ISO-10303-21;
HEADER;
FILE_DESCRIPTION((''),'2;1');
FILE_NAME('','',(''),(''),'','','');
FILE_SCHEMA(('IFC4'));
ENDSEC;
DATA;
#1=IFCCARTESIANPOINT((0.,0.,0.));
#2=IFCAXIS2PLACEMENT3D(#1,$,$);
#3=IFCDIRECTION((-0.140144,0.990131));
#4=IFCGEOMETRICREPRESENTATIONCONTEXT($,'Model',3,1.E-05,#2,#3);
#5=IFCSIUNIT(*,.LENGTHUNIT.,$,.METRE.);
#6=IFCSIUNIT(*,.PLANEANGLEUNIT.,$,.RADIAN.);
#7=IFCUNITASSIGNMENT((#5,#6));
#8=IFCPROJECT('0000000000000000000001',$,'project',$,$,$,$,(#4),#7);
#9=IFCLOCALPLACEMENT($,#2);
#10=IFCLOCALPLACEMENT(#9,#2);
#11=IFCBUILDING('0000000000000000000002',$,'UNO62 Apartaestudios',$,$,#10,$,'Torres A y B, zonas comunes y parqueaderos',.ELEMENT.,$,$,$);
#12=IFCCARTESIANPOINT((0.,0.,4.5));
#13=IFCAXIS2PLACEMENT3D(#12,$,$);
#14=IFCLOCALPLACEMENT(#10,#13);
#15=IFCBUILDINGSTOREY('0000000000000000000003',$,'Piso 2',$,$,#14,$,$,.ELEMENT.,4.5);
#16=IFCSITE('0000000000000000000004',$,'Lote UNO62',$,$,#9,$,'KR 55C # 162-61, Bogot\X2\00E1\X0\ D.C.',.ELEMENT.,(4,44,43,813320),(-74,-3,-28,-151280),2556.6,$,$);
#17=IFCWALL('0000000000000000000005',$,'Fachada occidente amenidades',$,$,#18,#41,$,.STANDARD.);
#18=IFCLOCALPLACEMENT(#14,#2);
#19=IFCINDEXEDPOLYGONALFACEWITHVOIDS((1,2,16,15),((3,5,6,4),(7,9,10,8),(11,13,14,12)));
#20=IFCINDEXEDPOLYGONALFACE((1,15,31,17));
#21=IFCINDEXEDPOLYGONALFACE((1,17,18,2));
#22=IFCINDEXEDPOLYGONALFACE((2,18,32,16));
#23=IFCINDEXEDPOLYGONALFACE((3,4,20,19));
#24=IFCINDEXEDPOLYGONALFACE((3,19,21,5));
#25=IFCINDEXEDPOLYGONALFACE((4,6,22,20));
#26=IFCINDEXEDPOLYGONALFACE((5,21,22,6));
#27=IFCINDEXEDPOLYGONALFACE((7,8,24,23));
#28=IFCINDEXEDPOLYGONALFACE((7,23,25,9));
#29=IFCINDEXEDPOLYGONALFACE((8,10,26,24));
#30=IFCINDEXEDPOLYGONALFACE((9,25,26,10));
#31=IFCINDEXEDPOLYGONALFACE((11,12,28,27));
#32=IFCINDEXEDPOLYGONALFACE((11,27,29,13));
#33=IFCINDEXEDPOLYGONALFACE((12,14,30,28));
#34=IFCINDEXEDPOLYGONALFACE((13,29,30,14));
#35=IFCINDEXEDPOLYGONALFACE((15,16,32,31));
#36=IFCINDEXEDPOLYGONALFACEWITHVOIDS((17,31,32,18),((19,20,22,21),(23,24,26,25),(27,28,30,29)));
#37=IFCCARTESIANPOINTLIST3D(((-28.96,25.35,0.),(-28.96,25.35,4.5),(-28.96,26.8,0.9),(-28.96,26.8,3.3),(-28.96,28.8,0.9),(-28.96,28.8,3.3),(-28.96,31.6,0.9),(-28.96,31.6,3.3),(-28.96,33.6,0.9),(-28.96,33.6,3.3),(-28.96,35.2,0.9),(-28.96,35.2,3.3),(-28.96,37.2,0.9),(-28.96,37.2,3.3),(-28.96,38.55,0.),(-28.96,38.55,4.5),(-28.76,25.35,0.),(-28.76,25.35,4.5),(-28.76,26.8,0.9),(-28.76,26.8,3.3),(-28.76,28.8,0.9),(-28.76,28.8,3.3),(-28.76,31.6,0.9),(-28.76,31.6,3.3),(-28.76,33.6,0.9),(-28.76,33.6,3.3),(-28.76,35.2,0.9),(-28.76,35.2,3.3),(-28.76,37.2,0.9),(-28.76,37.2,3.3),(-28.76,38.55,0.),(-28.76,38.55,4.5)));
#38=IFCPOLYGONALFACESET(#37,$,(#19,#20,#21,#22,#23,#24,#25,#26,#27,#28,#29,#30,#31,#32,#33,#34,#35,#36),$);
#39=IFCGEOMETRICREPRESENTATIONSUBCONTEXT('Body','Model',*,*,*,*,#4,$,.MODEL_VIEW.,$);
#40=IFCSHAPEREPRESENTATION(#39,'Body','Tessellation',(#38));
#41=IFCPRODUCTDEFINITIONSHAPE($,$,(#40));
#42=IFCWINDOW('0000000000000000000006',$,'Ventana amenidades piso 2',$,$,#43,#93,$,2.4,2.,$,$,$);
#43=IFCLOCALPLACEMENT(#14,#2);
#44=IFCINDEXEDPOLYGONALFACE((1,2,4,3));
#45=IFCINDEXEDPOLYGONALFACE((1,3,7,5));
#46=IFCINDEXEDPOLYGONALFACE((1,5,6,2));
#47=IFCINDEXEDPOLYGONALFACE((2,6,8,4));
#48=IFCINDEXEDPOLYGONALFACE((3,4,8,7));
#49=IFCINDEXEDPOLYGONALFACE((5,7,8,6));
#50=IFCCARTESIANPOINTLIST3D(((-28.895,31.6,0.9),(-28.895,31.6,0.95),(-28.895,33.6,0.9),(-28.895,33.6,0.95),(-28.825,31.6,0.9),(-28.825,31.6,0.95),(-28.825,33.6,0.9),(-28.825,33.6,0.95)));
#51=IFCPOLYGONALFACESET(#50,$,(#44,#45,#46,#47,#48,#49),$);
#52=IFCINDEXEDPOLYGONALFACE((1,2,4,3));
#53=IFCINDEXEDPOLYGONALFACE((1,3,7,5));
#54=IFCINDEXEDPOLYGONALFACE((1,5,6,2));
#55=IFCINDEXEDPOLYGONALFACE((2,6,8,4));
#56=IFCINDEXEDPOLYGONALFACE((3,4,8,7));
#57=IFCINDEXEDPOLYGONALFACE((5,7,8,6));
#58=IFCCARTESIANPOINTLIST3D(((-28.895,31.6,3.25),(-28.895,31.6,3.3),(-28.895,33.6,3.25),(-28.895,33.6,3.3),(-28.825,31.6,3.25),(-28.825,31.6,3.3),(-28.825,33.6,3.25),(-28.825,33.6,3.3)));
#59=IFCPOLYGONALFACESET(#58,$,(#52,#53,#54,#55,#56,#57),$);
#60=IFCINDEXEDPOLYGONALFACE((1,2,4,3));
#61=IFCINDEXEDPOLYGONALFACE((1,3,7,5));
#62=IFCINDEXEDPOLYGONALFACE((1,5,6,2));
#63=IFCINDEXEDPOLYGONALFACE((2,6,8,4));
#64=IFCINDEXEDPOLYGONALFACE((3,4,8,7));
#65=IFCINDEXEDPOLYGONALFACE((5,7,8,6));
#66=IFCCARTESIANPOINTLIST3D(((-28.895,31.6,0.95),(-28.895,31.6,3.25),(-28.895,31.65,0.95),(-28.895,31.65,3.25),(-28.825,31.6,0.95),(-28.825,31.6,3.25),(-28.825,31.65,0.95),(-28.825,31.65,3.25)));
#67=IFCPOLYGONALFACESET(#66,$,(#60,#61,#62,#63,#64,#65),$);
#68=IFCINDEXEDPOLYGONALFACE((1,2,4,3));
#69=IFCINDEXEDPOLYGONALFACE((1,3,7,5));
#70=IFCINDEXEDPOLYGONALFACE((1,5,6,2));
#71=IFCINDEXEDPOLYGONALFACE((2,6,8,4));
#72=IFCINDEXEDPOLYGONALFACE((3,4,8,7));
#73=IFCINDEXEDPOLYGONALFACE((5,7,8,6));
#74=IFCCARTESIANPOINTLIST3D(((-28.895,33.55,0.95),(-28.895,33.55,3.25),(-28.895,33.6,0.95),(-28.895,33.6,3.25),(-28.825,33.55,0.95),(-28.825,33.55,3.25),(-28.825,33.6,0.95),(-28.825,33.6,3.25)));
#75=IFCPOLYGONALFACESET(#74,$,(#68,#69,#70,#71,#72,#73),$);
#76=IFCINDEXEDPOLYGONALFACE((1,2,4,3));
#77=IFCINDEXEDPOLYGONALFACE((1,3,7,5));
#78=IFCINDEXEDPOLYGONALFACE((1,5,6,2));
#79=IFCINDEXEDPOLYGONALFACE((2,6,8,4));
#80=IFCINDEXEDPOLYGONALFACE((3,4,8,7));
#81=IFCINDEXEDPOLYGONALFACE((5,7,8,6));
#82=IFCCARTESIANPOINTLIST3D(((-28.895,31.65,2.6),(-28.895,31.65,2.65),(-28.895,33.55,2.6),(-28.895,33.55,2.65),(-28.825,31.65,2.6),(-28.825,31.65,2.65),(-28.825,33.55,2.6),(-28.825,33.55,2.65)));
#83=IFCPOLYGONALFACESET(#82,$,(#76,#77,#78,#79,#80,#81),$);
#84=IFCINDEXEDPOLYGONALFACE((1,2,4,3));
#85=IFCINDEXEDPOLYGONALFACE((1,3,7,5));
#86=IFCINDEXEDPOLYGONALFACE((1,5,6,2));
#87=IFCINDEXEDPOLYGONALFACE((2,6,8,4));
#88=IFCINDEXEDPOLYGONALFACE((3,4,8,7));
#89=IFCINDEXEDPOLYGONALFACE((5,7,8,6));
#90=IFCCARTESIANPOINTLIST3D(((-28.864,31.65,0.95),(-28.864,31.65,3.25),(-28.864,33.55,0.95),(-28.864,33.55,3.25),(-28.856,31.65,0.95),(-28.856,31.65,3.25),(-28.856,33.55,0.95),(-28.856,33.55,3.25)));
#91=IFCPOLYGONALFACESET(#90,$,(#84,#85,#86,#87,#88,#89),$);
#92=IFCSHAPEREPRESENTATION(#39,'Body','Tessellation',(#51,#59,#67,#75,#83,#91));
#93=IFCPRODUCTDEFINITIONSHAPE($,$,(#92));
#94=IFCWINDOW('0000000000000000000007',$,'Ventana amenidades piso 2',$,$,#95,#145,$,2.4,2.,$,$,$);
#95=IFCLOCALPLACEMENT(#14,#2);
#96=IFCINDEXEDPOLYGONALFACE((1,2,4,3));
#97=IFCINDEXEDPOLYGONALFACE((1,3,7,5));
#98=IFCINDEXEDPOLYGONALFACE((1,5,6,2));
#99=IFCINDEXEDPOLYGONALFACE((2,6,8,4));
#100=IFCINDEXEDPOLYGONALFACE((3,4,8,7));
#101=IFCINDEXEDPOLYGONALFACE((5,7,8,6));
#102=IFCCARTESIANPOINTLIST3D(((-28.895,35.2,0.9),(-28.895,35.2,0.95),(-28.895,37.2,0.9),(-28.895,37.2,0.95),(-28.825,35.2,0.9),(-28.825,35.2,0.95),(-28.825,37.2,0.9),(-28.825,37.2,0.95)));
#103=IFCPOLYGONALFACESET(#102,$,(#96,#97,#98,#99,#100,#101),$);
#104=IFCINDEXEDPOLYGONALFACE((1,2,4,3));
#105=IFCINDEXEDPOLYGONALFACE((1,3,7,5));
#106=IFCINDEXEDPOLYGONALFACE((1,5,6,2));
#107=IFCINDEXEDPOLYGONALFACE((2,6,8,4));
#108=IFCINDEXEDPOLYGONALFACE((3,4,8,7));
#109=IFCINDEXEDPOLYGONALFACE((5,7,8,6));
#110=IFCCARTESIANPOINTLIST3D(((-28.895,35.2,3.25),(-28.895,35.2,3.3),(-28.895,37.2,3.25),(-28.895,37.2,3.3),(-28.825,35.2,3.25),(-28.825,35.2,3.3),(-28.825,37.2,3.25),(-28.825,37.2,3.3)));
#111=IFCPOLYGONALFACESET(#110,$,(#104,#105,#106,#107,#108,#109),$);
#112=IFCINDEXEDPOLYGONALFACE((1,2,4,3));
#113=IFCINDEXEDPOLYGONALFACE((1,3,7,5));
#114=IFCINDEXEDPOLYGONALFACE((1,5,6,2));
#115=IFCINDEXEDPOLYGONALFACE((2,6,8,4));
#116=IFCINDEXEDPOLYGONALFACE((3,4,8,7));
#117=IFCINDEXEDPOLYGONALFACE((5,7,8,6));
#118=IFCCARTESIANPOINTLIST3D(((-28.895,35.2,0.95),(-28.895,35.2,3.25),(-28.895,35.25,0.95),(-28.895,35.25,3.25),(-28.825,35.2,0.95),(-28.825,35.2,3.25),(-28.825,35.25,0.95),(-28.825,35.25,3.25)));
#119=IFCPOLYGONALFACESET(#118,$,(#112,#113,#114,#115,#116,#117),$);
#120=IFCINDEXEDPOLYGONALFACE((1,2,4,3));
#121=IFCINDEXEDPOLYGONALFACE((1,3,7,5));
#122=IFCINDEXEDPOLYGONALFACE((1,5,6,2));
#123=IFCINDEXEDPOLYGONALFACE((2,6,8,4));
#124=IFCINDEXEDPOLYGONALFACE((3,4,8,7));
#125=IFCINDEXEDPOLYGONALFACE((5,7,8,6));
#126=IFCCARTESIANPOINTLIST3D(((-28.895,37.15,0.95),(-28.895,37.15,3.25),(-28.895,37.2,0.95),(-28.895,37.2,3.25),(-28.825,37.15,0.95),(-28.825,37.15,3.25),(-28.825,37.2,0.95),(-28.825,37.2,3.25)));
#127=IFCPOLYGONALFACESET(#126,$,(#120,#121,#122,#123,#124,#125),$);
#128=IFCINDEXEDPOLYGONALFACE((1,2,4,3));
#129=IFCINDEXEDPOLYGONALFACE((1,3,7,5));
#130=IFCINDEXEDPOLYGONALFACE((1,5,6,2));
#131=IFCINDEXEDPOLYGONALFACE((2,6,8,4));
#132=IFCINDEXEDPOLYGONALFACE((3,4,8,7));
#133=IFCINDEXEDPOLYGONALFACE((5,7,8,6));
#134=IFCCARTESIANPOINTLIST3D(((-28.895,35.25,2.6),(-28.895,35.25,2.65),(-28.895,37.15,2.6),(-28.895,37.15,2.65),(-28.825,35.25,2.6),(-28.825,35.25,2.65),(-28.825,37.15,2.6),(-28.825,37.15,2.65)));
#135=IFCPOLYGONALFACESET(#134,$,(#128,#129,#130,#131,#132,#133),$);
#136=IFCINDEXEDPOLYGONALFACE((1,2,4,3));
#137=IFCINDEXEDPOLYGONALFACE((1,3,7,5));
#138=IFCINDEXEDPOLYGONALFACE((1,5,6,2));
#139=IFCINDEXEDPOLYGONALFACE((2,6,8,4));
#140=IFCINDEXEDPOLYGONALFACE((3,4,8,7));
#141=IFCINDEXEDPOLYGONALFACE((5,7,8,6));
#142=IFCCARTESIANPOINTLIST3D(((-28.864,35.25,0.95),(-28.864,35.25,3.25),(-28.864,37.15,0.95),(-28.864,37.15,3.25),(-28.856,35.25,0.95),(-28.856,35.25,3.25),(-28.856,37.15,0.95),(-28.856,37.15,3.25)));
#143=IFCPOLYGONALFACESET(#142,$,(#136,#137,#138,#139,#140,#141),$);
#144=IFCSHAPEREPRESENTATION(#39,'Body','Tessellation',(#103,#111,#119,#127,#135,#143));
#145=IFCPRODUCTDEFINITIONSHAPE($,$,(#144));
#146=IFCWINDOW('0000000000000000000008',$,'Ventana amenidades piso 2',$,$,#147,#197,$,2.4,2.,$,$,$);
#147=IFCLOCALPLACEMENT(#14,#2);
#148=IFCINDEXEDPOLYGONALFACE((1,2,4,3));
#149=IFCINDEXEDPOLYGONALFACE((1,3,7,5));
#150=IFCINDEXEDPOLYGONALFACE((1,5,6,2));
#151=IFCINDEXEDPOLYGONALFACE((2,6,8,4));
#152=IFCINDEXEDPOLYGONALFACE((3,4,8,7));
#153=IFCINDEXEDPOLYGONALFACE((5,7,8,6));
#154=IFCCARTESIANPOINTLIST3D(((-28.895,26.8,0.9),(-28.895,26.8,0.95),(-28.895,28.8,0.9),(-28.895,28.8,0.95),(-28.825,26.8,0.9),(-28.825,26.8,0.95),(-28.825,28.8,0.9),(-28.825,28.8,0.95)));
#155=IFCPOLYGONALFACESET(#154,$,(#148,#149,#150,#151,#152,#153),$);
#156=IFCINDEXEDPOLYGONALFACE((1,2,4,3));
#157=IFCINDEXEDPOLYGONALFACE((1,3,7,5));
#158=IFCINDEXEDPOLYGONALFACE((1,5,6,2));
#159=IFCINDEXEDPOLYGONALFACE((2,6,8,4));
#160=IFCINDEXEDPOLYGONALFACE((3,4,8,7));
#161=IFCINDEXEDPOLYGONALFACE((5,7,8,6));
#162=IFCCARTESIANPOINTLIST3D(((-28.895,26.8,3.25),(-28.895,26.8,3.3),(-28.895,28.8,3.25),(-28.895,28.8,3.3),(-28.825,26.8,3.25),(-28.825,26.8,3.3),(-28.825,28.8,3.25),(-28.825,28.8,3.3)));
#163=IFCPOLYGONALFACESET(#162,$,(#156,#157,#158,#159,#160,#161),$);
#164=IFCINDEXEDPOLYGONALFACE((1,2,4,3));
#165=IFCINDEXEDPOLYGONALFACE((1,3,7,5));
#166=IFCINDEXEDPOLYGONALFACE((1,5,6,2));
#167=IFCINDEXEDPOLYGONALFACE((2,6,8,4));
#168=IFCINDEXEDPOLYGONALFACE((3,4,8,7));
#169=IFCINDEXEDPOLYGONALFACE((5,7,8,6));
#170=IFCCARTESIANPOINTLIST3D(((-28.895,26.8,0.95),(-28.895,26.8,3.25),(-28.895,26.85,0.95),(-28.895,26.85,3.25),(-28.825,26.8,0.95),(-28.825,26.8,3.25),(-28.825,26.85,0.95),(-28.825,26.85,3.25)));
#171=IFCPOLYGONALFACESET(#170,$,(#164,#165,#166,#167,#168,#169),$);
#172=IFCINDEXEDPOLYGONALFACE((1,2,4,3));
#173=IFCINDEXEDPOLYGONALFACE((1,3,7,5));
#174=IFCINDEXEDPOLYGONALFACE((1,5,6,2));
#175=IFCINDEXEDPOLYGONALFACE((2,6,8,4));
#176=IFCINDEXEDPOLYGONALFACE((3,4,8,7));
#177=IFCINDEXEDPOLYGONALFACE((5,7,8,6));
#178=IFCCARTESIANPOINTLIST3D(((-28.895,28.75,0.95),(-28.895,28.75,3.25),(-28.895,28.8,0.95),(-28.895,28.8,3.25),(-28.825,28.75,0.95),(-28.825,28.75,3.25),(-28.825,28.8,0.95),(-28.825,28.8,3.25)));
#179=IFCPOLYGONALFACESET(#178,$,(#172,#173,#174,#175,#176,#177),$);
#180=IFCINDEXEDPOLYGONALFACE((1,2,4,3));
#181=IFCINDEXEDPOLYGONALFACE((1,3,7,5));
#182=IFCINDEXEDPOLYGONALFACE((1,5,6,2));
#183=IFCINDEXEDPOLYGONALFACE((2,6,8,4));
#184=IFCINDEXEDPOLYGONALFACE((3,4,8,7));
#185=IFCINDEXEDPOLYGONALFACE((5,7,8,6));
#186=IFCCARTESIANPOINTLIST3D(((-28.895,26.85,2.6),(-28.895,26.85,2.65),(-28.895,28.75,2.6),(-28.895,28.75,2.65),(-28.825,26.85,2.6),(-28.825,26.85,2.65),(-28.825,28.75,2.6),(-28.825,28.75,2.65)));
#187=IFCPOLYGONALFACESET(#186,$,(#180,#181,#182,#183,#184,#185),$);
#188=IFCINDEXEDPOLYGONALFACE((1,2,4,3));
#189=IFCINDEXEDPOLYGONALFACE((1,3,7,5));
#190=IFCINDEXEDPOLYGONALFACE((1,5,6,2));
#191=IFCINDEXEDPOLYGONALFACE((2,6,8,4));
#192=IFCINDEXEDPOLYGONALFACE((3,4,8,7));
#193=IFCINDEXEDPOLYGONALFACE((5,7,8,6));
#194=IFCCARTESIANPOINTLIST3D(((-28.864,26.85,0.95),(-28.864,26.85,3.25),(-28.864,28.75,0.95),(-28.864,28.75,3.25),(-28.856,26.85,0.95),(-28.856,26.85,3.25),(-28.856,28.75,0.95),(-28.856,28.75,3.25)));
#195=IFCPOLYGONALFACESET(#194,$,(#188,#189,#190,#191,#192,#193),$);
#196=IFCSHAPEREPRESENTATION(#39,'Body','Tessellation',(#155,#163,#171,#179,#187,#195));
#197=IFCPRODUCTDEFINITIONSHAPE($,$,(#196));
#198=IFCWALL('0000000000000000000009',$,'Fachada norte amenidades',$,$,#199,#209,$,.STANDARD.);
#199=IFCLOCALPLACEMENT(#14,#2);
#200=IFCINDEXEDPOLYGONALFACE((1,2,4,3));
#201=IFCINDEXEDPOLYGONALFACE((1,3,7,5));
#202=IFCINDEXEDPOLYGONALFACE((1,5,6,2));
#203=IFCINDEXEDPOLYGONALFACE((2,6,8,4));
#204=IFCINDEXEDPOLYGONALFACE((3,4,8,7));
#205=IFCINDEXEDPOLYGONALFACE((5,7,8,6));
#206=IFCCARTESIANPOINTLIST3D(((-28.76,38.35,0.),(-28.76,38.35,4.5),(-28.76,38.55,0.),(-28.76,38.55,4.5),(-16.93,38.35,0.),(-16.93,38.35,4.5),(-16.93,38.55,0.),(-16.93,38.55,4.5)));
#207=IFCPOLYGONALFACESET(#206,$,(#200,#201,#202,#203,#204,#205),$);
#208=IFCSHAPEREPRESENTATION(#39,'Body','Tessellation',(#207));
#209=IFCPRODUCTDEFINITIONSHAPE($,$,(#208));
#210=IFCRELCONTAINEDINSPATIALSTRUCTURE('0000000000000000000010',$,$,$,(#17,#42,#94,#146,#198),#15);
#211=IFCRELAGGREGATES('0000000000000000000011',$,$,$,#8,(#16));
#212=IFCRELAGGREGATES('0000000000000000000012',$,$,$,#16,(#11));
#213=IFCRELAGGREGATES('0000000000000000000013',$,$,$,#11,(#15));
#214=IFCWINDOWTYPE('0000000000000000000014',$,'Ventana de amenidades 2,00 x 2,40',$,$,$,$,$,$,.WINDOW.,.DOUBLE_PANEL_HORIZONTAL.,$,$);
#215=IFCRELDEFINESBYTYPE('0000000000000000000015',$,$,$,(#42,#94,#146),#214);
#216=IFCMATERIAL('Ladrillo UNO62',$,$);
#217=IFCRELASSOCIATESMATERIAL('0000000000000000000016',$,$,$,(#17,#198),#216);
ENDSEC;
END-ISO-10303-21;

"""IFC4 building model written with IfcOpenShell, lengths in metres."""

from ifc_helpers import new_model, si_unit, direction, frame, frame_2d, origin, place, context, subcontext, project, spatial, rectangle, extrude, source, transform, mapped, material, type_object, type_shapes, element, fill, save


model = new_model("IFC4")

# Units and contexts
model_context = context("Model", 3, precision=1e-05, world=origin(), true_north=direction((-0.140144, 0.990131)))
body_context = subcontext(model_context, "Body", "Model", "MODEL_VIEW")
ifc_project = project(units=[si_unit("LENGTHUNIT", "METRE"), si_unit("PLANEANGLEUNIT", "RADIAN")], contexts=[model_context])

# Site, building, storey
site_placement = place(None, origin())
site = spatial("IfcSite", under=ifc_project, at=site_placement, Name="Lote UNO62", LongName="KR 55C # 162-61, Bogotá D.C.", CompositionType="ELEMENT", RefLatitude=(4, 44, 43, 813320), RefLongitude=(-74, -3, -28, -151280), RefElevation=2556.6)
building_placement = place(site_placement, origin())
building = spatial("IfcBuilding", under=site, at=building_placement, Name="UNO62 Apartaestudios", LongName="Torres A y B, zonas comunes y parqueaderos", CompositionType="ELEMENT")
storey_placement = place(building_placement, frame((0.0, 0.0, 4.5)))
storey = spatial("IfcBuildingStorey", under=building, at=storey_placement, Name="Piso 2", CompositionType="ELEMENT", Elevation=4.5)

# Wall, openings, windows
ifc_material_1 = material(Name="Ladrillo UNO62")
wall_1_placement = place(storey_placement, origin())
wall_1 = element("IfcWall", 1, at=wall_1_placement, inside=storey, material=ifc_material_1, Name="Fachada occidente amenidades", PredefinedType="STANDARD", context=body_context, shape_type="SweptSolid", body=[
    extrude(rectangle(XDim=0.2, YDim=13.2, at=frame_2d((-28.86, 31.95))), origin(), (0.0, 0.0, 1.0), 4.5),
])
opening_1_placement = place(wall_1_placement, origin())
opening_1 = element("IfcOpeningElement", 2, at=opening_1_placement, cuts=wall_1, PredefinedType="OPENING", context=body_context, shape_type="SweptSolid", body=[
    extrude(rectangle(XDim=0.3, YDim=2.0, at=frame_2d((-28.86, 32.6))), frame((0.0, 0.0, 0.9)), (0.0, 0.0, 1.0), 2.4),
])
opening_2_placement = place(wall_1_placement, origin())
opening_2 = element("IfcOpeningElement", 3, at=opening_2_placement, cuts=wall_1, PredefinedType="OPENING", context=body_context, shape_type="SweptSolid", body=[
    extrude(rectangle(XDim=0.3, YDim=2.0, at=frame_2d((-28.86, 36.2))), frame((0.0, 0.0, 0.9)), (0.0, 0.0, 1.0), 2.4),
])
opening_3_placement = place(wall_1_placement, origin())
opening_3 = element("IfcOpeningElement", 4, at=opening_3_placement, cuts=wall_1, PredefinedType="OPENING", context=body_context, shape_type="SweptSolid", body=[
    extrude(rectangle(XDim=0.3, YDim=2.0, at=frame_2d((-28.86, 27.8))), frame((0.0, 0.0, 0.9)), (0.0, 0.0, 1.0), 2.4),
])
window_type = type_object("IfcWindowType", Name="Ventana de amenidades 2,00 x 2,40", PartitioningType="DOUBLE_PANEL_HORIZONTAL", PredefinedType="WINDOW")
shared_shape_1 = source(origin(), body_context, "Body", "SweptSolid", [
    extrude(rectangle(XDim=2.0, YDim=0.07, at=frame_2d((1.0, 0.0))), origin(), (0.0, 0.0, 1.0), 0.05),
    extrude(rectangle(XDim=2.0, YDim=0.07, at=frame_2d((1.0, 0.0))), frame((0.0, 0.0, 2.35)), (0.0, 0.0, 1.0), 0.05),
    extrude(rectangle(XDim=0.05, YDim=0.07, at=frame_2d((0.025, 0.0))), frame((0.0, 0.0, 0.05)), (0.0, 0.0, 1.0), 2.3),
    extrude(rectangle(XDim=0.05, YDim=0.07, at=frame_2d((1.975, 0.0))), frame((0.0, 0.0, 0.05)), (0.0, 0.0, 1.0), 2.3),
    extrude(rectangle(XDim=1.9, YDim=0.07, at=frame_2d((1.0, 0.0))), frame((0.0, 0.0, 1.7)), (0.0, 0.0, 1.0), 0.05),
    extrude(rectangle(XDim=1.9, YDim=0.008, at=frame_2d((1.0, 0.0))), frame((0.0, 0.0, 0.05)), (0.0, 0.0, 1.0), 2.3),
])
type_shapes(window_type, [shared_shape_1])
window_1_placement = place(storey_placement, frame((-28.86, 31.6, 0.9), z_axis=(0.0, 0.0, 1.0), x_axis=(0.0, 1.0, 0.0)))
window_1 = element("IfcWindow", 5, at=window_1_placement, inside=storey, type_object=window_type, Name="Ventana amenidades piso 2", OverallHeight=2.4, OverallWidth=2.0, context=body_context, shape_type="MappedRepresentation", body=[
    mapped(shared_shape_1, transform((0.0, 0.0, 0.0))),
])
fill(opening_1, window_1)
window_2_placement = place(storey_placement, frame((-28.86, 35.2, 0.9), z_axis=(0.0, 0.0, 1.0), x_axis=(0.0, 1.0, 0.0)))
window_2 = element("IfcWindow", 6, at=window_2_placement, inside=storey, type_object=window_type, Name="Ventana amenidades piso 2", OverallHeight=2.4, OverallWidth=2.0, context=body_context, shape_type="MappedRepresentation", body=[
    mapped(shared_shape_1, transform((0.0, 0.0, 0.0))),
])
fill(opening_2, window_2)
window_3_placement = place(storey_placement, frame((-28.86, 26.8, 0.9), z_axis=(0.0, 0.0, 1.0), x_axis=(0.0, 1.0, 0.0)))
window_3 = element("IfcWindow", 7, at=window_3_placement, inside=storey, type_object=window_type, Name="Ventana amenidades piso 2", OverallHeight=2.4, OverallWidth=2.0, context=body_context, shape_type="MappedRepresentation", body=[
    mapped(shared_shape_1, transform((0.0, 0.0, 0.0))),
])
fill(opening_3, window_3)

# Wall
wall_2_placement = place(storey_placement, origin())
element("IfcWall", 8, at=wall_2_placement, inside=storey, material=ifc_material_1, Name="Fachada norte amenidades", PredefinedType="STANDARD", context=body_context, shape_type="SweptSolid", body=[
    extrude(rectangle(XDim=11.83, YDim=0.2, at=frame_2d((-22.845, 38.45))), origin(), (0.0, 0.0, 1.0), 4.5),
])

save(model, "model.ifc")
